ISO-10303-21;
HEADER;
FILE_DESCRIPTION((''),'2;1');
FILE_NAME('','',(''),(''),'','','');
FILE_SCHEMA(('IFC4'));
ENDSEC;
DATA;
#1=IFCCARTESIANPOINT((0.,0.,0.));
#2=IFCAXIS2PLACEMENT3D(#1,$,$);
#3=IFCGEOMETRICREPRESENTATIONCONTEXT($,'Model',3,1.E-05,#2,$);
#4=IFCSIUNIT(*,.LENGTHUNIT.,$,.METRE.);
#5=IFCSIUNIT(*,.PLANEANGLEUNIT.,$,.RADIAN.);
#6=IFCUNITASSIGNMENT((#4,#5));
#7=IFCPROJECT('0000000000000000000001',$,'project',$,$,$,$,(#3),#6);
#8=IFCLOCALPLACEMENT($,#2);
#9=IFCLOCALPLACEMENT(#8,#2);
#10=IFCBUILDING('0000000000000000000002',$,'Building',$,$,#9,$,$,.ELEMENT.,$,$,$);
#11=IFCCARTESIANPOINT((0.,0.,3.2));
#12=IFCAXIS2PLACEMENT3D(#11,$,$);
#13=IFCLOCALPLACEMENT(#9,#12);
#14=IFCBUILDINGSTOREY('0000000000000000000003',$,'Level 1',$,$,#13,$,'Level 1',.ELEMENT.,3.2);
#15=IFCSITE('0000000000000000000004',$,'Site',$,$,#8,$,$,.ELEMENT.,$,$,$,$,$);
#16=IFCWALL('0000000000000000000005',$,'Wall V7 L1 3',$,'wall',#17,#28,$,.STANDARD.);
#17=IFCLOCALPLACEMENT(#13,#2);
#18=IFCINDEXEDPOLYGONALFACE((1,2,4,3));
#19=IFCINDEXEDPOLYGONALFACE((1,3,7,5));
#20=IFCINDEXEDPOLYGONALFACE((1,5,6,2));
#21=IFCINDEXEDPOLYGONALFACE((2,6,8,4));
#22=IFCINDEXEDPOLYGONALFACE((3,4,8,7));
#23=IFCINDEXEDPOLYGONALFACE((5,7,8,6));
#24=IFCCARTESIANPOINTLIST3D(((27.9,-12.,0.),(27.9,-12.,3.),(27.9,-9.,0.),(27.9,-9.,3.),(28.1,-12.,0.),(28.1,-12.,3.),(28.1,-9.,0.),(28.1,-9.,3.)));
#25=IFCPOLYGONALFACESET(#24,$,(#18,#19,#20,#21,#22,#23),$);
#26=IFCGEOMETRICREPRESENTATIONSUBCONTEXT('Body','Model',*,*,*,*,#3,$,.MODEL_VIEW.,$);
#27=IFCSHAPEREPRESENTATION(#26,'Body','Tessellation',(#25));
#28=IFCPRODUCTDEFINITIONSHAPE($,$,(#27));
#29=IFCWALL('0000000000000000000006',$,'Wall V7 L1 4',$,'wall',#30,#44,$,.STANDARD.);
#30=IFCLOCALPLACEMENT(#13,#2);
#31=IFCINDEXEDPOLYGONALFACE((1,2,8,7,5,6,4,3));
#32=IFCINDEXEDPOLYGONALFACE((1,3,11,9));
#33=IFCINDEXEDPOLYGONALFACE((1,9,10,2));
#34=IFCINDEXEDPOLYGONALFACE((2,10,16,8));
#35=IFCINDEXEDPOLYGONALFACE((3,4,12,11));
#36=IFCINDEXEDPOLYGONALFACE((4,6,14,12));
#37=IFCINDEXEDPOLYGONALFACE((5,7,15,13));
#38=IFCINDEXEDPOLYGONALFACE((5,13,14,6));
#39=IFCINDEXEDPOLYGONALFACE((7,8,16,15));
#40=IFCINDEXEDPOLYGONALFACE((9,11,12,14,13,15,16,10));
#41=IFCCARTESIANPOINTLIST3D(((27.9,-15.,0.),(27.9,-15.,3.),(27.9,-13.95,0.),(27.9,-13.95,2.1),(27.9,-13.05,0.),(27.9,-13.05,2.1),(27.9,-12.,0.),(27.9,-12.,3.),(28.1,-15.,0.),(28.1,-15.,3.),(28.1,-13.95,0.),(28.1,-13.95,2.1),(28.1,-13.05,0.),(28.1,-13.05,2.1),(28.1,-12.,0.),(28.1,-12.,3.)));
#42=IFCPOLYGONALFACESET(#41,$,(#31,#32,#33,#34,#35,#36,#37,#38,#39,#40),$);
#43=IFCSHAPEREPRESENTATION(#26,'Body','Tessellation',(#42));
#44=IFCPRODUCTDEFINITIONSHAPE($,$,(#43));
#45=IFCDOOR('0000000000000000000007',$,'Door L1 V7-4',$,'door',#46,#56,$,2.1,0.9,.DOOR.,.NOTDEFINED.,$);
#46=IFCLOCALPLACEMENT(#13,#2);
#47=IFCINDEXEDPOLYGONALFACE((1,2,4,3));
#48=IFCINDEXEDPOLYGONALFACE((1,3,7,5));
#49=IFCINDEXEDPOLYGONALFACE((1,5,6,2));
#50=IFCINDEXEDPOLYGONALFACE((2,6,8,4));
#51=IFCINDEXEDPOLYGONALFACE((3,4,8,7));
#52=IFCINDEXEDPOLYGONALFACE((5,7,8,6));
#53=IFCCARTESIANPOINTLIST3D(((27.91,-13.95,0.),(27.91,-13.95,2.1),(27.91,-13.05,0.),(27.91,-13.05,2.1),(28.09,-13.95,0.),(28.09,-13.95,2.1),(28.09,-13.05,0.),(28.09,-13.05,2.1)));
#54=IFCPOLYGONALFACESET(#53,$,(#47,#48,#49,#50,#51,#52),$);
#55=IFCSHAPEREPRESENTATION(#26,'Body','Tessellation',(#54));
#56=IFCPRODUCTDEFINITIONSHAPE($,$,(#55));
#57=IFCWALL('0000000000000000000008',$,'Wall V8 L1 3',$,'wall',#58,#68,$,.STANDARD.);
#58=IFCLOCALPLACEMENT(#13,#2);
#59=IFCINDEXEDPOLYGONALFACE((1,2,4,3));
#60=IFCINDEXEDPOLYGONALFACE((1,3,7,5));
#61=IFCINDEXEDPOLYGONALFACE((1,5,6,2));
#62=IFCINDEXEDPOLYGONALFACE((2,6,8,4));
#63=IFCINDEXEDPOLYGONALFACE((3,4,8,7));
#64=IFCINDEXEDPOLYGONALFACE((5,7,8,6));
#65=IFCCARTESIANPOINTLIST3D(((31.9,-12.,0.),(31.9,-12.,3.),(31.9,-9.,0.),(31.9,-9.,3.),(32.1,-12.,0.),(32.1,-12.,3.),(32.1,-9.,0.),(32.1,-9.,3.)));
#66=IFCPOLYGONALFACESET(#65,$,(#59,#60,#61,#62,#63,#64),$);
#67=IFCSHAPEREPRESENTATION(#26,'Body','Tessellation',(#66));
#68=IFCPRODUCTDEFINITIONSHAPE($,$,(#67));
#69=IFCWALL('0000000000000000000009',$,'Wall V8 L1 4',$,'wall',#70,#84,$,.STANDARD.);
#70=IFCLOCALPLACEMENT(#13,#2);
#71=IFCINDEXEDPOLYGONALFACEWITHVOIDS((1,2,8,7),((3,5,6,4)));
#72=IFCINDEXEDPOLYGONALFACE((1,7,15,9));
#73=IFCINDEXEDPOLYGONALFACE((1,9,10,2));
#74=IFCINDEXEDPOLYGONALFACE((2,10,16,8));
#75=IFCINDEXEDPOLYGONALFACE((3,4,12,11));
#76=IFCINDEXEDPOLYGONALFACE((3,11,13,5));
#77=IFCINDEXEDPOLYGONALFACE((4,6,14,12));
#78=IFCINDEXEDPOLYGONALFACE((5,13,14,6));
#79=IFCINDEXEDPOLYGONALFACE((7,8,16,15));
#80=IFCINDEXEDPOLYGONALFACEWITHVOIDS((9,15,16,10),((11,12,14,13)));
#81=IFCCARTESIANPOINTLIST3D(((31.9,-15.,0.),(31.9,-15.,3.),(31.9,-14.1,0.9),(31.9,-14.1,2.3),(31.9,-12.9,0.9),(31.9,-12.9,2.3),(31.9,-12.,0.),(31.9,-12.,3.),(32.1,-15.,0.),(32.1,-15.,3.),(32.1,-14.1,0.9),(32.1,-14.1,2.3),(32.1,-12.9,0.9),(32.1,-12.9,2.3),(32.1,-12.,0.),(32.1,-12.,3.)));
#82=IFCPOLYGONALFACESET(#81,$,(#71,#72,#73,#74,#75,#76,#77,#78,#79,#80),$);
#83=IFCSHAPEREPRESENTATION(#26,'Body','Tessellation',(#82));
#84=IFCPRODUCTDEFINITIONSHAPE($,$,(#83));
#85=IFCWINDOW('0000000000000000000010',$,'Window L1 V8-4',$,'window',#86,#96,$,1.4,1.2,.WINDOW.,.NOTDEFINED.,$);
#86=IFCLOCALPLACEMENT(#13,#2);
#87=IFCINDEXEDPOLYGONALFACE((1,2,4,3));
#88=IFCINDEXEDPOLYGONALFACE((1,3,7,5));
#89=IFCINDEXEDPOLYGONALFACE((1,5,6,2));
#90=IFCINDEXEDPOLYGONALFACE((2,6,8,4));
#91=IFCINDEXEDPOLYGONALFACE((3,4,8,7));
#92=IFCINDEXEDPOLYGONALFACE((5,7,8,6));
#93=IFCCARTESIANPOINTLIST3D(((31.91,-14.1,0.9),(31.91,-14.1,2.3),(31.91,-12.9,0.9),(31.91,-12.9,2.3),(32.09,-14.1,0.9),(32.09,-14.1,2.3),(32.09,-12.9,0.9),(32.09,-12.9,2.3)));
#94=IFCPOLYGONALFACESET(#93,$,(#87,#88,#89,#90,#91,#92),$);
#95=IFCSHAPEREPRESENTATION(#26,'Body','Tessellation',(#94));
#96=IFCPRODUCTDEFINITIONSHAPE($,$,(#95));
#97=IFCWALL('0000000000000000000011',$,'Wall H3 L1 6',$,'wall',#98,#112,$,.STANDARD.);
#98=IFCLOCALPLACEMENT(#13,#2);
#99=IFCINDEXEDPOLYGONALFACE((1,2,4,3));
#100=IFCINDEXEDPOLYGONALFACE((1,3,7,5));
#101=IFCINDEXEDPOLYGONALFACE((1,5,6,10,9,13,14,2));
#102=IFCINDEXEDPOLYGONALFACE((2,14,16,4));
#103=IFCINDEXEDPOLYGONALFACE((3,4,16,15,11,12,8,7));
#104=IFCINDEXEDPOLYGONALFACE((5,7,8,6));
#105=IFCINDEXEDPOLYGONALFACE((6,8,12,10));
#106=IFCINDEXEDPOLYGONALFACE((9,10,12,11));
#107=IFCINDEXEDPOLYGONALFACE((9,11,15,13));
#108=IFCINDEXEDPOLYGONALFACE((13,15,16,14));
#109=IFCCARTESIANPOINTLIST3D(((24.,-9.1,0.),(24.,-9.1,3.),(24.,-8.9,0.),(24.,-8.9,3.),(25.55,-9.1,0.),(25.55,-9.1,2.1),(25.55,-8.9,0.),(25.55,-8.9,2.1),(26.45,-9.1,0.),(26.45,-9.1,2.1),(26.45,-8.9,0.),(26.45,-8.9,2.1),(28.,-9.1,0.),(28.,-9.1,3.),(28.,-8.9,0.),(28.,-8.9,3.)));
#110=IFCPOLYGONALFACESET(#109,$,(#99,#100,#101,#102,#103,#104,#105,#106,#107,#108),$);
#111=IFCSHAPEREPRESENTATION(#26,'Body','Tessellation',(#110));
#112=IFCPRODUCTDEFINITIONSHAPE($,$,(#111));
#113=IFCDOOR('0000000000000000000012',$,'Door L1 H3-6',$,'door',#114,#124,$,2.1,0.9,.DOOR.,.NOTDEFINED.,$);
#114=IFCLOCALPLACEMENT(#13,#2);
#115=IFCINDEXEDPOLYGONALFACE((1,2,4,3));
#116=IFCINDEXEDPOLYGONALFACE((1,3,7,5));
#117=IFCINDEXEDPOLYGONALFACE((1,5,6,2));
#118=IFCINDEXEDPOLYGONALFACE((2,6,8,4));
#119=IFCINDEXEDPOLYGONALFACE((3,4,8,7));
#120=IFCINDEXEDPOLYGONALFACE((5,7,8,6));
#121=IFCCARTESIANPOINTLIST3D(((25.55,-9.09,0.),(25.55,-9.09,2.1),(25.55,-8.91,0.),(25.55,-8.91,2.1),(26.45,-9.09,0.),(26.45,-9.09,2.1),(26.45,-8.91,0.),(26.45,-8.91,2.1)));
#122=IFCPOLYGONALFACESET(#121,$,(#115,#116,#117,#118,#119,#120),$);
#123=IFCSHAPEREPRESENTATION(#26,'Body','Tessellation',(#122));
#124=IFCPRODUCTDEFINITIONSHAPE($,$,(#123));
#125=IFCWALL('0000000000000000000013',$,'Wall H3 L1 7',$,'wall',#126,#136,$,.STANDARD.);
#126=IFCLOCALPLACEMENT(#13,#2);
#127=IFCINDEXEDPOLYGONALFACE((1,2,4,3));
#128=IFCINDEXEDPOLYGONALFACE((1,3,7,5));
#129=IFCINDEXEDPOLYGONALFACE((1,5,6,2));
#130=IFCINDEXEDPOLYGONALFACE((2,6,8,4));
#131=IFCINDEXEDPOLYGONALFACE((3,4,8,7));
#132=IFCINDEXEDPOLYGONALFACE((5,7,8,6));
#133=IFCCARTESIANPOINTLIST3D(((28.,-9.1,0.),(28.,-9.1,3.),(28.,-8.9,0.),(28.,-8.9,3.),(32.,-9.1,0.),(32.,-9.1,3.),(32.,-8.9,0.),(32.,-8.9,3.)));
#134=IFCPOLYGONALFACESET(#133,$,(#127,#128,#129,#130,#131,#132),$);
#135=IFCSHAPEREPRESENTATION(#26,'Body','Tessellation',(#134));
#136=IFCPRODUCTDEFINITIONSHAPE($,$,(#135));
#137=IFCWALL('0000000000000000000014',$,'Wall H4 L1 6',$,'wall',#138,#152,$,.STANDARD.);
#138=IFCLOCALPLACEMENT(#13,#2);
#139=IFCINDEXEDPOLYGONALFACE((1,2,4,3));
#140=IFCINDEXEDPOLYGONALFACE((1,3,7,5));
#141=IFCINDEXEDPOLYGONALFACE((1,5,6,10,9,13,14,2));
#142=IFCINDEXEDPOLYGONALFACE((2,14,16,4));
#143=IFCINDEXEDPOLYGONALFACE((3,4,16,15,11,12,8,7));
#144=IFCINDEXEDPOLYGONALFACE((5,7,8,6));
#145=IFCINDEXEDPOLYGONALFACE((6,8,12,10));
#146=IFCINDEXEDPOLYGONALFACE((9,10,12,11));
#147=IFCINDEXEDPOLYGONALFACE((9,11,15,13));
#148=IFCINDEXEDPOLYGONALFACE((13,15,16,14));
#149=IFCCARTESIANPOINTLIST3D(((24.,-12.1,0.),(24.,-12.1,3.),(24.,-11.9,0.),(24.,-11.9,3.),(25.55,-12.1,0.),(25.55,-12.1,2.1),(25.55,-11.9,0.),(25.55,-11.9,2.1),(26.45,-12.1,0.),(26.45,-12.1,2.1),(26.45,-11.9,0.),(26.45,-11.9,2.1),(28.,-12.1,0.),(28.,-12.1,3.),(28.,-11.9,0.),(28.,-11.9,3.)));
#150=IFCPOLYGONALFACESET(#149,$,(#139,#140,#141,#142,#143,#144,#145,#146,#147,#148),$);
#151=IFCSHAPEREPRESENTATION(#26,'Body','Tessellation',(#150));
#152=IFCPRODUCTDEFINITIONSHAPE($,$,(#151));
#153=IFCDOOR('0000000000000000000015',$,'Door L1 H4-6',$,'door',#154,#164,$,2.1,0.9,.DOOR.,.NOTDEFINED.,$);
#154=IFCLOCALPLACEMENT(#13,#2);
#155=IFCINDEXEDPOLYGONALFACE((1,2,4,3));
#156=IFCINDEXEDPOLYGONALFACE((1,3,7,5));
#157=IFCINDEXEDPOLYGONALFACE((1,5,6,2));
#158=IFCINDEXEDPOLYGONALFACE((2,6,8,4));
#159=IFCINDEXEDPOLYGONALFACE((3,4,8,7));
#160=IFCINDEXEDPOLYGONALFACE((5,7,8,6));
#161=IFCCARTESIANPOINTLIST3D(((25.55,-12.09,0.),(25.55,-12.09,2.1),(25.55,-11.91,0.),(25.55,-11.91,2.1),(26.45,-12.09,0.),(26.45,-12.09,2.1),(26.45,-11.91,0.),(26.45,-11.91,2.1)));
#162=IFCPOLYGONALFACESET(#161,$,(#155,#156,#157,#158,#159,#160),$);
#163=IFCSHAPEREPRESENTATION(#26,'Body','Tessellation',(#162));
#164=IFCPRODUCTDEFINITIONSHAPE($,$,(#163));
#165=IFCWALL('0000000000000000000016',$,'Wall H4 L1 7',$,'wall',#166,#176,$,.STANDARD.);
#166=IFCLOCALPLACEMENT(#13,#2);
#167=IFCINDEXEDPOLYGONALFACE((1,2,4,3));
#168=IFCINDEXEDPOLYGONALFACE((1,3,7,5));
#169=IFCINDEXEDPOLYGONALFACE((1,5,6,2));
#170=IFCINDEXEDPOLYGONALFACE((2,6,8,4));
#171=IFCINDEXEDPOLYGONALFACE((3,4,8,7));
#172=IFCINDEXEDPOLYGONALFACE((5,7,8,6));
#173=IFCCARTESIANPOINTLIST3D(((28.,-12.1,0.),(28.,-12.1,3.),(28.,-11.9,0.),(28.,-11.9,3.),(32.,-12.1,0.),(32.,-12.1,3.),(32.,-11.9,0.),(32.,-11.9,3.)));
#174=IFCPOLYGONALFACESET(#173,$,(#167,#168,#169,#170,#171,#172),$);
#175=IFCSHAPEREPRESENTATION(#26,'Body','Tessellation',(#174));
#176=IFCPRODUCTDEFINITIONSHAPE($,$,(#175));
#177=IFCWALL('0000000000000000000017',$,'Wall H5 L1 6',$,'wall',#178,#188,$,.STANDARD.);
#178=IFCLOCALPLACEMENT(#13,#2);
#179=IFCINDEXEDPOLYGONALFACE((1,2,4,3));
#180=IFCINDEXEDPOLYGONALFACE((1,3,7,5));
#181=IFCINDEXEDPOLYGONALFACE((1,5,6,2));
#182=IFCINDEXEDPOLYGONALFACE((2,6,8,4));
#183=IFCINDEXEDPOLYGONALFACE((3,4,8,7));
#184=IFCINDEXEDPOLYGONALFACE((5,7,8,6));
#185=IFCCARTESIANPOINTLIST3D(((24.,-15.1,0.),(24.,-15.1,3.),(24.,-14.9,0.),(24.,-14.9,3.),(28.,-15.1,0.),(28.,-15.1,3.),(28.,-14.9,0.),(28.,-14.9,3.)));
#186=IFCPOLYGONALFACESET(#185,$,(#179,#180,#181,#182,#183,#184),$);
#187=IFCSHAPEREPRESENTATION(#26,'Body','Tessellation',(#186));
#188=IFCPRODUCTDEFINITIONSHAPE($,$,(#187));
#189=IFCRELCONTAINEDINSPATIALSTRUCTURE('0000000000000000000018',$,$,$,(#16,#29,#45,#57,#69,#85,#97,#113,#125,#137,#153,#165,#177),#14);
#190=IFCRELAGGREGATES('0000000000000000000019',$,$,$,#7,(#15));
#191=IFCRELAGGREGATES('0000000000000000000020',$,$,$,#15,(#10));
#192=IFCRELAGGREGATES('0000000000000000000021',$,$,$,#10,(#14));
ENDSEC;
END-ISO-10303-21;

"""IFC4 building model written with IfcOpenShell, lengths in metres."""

from ifc_helpers import new_model, si_unit, frame, frame_2d, origin, origin_2d, place, context, subcontext, project, spatial, rectangle, extrude, element, fill, save


model = new_model("IFC4")

# Units and contexts
model_context = context("Model", 3, precision=1e-05, world=origin())
body_context = subcontext(model_context, "Body", "Model", "MODEL_VIEW")
ifc_project = project(units=[si_unit("LENGTHUNIT", "METRE"), si_unit("PLANEANGLEUNIT", "RADIAN")], contexts=[model_context])

# Site, building, storey
site_placement = place(None, origin())
site = spatial("IfcSite", under=ifc_project, at=site_placement, Name="Site", CompositionType="ELEMENT")
building_placement = place(site_placement, origin())
building = spatial("IfcBuilding", under=site, at=building_placement, Name="Building", CompositionType="ELEMENT")
storey_placement = place(building_placement, frame((0.0, 0.0, 3.2)))
storey = spatial("IfcBuildingStorey", under=building, at=storey_placement, Name="Level 1", LongName="Level 1", CompositionType="ELEMENT", Elevation=3.2)

# Wall
wall_1_placement = place(storey_placement, frame((28.0, -9.0, 0.0), z_axis=(0.0, 0.0, 1.0), x_axis=(0.0, -1.0, 0.0)))
element("IfcWall", 1, at=wall_1_placement, inside=storey, Name="Wall V7 L1 3", ObjectType="wall", PredefinedType="STANDARD", context=body_context, shape_type="SweptSolid", body=[
    extrude(rectangle(XDim=3.0, YDim=0.2, at=frame_2d((1.5, 0.0))), origin(), (0.0, 0.0, 1.0), 3.0),
])

# Wall, opening, door
wall_2_placement = place(storey_placement, frame((28.0, -12.0, 0.0), z_axis=(0.0, 0.0, 1.0), x_axis=(0.0, -1.0, 0.0)))
wall_2 = element("IfcWall", 2, at=wall_2_placement, inside=storey, Name="Wall V7 L1 4", ObjectType="wall", PredefinedType="STANDARD", context=body_context, shape_type="SweptSolid", body=[
    extrude(rectangle(XDim=3.0, YDim=0.2, at=frame_2d((1.5, 0.0))), origin(), (0.0, 0.0, 1.0), 3.0),
])
opening_1_placement = place(storey_placement, frame((28.0, -13.5, 0.0), z_axis=(0.0, 0.0, 1.0), x_axis=(0.0, -1.0, 0.0)))
opening_1 = element("IfcOpeningElement", 3, at=opening_1_placement, cuts=wall_2, ObjectType="Opening", PredefinedType="OPENING", context=body_context, shape_type="SweptSolid", body=[
    extrude(rectangle(XDim=0.9, YDim=0.22, at=origin_2d()), origin(), (0.0, 0.0, 1.0), 2.1),
])
door_1_placement = place(storey_placement, frame((28.0, -13.5, 0.0), z_axis=(0.0, 0.0, 1.0), x_axis=(0.0, -1.0, 0.0)))
door_1 = element("IfcDoor", 4, at=door_1_placement, inside=storey, Name="Door L1 V7-4", ObjectType="door", OperationType="NOTDEFINED", OverallHeight=2.1, OverallWidth=0.9, PredefinedType="DOOR", context=body_context, shape_type="SweptSolid", body=[
    extrude(rectangle(XDim=0.9, YDim=0.18, at=origin_2d()), origin(), (0.0, 0.0, 1.0), 2.1),
])
fill(opening_1, door_1)

# Wall
wall_3_placement = place(storey_placement, frame((32.0, -9.0, 0.0), z_axis=(0.0, 0.0, 1.0), x_axis=(0.0, -1.0, 0.0)))
element("IfcWall", 5, at=wall_3_placement, inside=storey, Name="Wall V8 L1 3", ObjectType="wall", PredefinedType="STANDARD", context=body_context, shape_type="SweptSolid", body=[
    extrude(rectangle(XDim=3.0, YDim=0.2, at=frame_2d((1.5, 0.0))), origin(), (0.0, 0.0, 1.0), 3.0),
])

# Wall, opening, window
wall_4_placement = place(storey_placement, frame((32.0, -12.0, 0.0), z_axis=(0.0, 0.0, 1.0), x_axis=(0.0, -1.0, 0.0)))
wall_4 = element("IfcWall", 6, at=wall_4_placement, inside=storey, Name="Wall V8 L1 4", ObjectType="wall", PredefinedType="STANDARD", context=body_context, shape_type="SweptSolid", body=[
    extrude(rectangle(XDim=3.0, YDim=0.2, at=frame_2d((1.5, 0.0))), origin(), (0.0, 0.0, 1.0), 3.0),
])
opening_2_placement = place(storey_placement, frame((32.0, -13.5, 0.9), z_axis=(0.0, 0.0, 1.0), x_axis=(0.0, -1.0, 0.0)))
opening_2 = element("IfcOpeningElement", 7, at=opening_2_placement, cuts=wall_4, ObjectType="Opening", PredefinedType="OPENING", context=body_context, shape_type="SweptSolid", body=[
    extrude(rectangle(XDim=1.2, YDim=0.22, at=origin_2d()), origin(), (0.0, 0.0, 1.0), 1.4),
])
window_1_placement = place(storey_placement, frame((32.0, -13.5, 0.9), z_axis=(0.0, 0.0, 1.0), x_axis=(0.0, -1.0, 0.0)))
window_1 = element("IfcWindow", 8, at=window_1_placement, inside=storey, Name="Window L1 V8-4", ObjectType="window", OverallHeight=1.4, OverallWidth=1.2, PartitioningType="NOTDEFINED", PredefinedType="WINDOW", context=body_context, shape_type="SweptSolid", body=[
    extrude(rectangle(XDim=1.2, YDim=0.18, at=origin_2d()), origin(), (0.0, 0.0, 1.0), 1.4),
])
fill(opening_2, window_1)

# Wall, opening, door
wall_5_placement = place(storey_placement, frame((24.0, -9.0, 0.0), z_axis=(0.0, 0.0, 1.0), x_axis=(1.0, 0.0, 0.0)))
wall_5 = element("IfcWall", 9, at=wall_5_placement, inside=storey, Name="Wall H3 L1 6", ObjectType="wall", PredefinedType="STANDARD", context=body_context, shape_type="SweptSolid", body=[
    extrude(rectangle(XDim=4.0, YDim=0.2, at=frame_2d((2.0, 0.0))), origin(), (0.0, 0.0, 1.0), 3.0),
])
opening_3_placement = place(storey_placement, frame((26.0, -9.0, 0.0), z_axis=(0.0, 0.0, 1.0), x_axis=(1.0, 0.0, 0.0)))
opening_3 = element("IfcOpeningElement", 10, at=opening_3_placement, cuts=wall_5, ObjectType="Opening", PredefinedType="OPENING", context=body_context, shape_type="SweptSolid", body=[
    extrude(rectangle(XDim=0.9, YDim=0.22, at=origin_2d()), origin(), (0.0, 0.0, 1.0), 2.1),
])
door_2_placement = place(storey_placement, frame((26.0, -9.0, 0.0), z_axis=(0.0, 0.0, 1.0), x_axis=(1.0, 0.0, 0.0)))
door_2 = element("IfcDoor", 11, at=door_2_placement, inside=storey, Name="Door L1 H3-6", ObjectType="door", OperationType="NOTDEFINED", OverallHeight=2.1, OverallWidth=0.9, PredefinedType="DOOR", context=body_context, shape_type="SweptSolid", body=[
    extrude(rectangle(XDim=0.9, YDim=0.18, at=origin_2d()), origin(), (0.0, 0.0, 1.0), 2.1),
])
fill(opening_3, door_2)

# Wall
wall_6_placement = place(storey_placement, frame((28.0, -9.0, 0.0), z_axis=(0.0, 0.0, 1.0), x_axis=(1.0, 0.0, 0.0)))
element("IfcWall", 12, at=wall_6_placement, inside=storey, Name="Wall H3 L1 7", ObjectType="wall", PredefinedType="STANDARD", context=body_context, shape_type="SweptSolid", body=[
    extrude(rectangle(XDim=4.0, YDim=0.2, at=frame_2d((2.0, 0.0))), origin(), (0.0, 0.0, 1.0), 3.0),
])

# Wall, opening, door
wall_7_placement = place(storey_placement, frame((24.0, -12.0, 0.0), z_axis=(0.0, 0.0, 1.0), x_axis=(1.0, 0.0, 0.0)))
wall_7 = element("IfcWall", 13, at=wall_7_placement, inside=storey, Name="Wall H4 L1 6", ObjectType="wall", PredefinedType="STANDARD", context=body_context, shape_type="SweptSolid", body=[
    extrude(rectangle(XDim=4.0, YDim=0.2, at=frame_2d((2.0, 0.0))), origin(), (0.0, 0.0, 1.0), 3.0),
])
opening_4_placement = place(storey_placement, frame((26.0, -12.0, 0.0), z_axis=(0.0, 0.0, 1.0), x_axis=(1.0, 0.0, 0.0)))
opening_4 = element("IfcOpeningElement", 14, at=opening_4_placement, cuts=wall_7, ObjectType="Opening", PredefinedType="OPENING", context=body_context, shape_type="SweptSolid", body=[
    extrude(rectangle(XDim=0.9, YDim=0.22, at=origin_2d()), origin(), (0.0, 0.0, 1.0), 2.1),
])
door_3_placement = place(storey_placement, frame((26.0, -12.0, 0.0), z_axis=(0.0, 0.0, 1.0), x_axis=(1.0, 0.0, 0.0)))
door_3 = element("IfcDoor", 15, at=door_3_placement, inside=storey, Name="Door L1 H4-6", ObjectType="door", OperationType="NOTDEFINED", OverallHeight=2.1, OverallWidth=0.9, PredefinedType="DOOR", context=body_context, shape_type="SweptSolid", body=[
    extrude(rectangle(XDim=0.9, YDim=0.18, at=origin_2d()), origin(), (0.0, 0.0, 1.0), 2.1),
])
fill(opening_4, door_3)

# Walls
for number, where, z_axis, x_axis, name in (
    (16, (28.0, -12.0, 0.0), (0.0, 0.0, 1.0), (1.0, 0.0, 0.0), "Wall H4 L1 7"),
    (17, (24.0, -15.0, 0.0), (0.0, 0.0, 1.0), (1.0, 0.0, 0.0), "Wall H5 L1 6"),
):
    element("IfcWall", number, at=place(storey_placement, frame(where, z_axis=z_axis, x_axis=x_axis)), inside=storey, Name=name, ObjectType="wall", PredefinedType="STANDARD", context=body_context, shape_type="SweptSolid", body=[
        extrude(rectangle(XDim=4.0, YDim=0.2, at=frame_2d((2.0, 0.0))), origin(), (0.0, 0.0, 1.0), 3.0),
    ])

save(model, "model.ifc")
